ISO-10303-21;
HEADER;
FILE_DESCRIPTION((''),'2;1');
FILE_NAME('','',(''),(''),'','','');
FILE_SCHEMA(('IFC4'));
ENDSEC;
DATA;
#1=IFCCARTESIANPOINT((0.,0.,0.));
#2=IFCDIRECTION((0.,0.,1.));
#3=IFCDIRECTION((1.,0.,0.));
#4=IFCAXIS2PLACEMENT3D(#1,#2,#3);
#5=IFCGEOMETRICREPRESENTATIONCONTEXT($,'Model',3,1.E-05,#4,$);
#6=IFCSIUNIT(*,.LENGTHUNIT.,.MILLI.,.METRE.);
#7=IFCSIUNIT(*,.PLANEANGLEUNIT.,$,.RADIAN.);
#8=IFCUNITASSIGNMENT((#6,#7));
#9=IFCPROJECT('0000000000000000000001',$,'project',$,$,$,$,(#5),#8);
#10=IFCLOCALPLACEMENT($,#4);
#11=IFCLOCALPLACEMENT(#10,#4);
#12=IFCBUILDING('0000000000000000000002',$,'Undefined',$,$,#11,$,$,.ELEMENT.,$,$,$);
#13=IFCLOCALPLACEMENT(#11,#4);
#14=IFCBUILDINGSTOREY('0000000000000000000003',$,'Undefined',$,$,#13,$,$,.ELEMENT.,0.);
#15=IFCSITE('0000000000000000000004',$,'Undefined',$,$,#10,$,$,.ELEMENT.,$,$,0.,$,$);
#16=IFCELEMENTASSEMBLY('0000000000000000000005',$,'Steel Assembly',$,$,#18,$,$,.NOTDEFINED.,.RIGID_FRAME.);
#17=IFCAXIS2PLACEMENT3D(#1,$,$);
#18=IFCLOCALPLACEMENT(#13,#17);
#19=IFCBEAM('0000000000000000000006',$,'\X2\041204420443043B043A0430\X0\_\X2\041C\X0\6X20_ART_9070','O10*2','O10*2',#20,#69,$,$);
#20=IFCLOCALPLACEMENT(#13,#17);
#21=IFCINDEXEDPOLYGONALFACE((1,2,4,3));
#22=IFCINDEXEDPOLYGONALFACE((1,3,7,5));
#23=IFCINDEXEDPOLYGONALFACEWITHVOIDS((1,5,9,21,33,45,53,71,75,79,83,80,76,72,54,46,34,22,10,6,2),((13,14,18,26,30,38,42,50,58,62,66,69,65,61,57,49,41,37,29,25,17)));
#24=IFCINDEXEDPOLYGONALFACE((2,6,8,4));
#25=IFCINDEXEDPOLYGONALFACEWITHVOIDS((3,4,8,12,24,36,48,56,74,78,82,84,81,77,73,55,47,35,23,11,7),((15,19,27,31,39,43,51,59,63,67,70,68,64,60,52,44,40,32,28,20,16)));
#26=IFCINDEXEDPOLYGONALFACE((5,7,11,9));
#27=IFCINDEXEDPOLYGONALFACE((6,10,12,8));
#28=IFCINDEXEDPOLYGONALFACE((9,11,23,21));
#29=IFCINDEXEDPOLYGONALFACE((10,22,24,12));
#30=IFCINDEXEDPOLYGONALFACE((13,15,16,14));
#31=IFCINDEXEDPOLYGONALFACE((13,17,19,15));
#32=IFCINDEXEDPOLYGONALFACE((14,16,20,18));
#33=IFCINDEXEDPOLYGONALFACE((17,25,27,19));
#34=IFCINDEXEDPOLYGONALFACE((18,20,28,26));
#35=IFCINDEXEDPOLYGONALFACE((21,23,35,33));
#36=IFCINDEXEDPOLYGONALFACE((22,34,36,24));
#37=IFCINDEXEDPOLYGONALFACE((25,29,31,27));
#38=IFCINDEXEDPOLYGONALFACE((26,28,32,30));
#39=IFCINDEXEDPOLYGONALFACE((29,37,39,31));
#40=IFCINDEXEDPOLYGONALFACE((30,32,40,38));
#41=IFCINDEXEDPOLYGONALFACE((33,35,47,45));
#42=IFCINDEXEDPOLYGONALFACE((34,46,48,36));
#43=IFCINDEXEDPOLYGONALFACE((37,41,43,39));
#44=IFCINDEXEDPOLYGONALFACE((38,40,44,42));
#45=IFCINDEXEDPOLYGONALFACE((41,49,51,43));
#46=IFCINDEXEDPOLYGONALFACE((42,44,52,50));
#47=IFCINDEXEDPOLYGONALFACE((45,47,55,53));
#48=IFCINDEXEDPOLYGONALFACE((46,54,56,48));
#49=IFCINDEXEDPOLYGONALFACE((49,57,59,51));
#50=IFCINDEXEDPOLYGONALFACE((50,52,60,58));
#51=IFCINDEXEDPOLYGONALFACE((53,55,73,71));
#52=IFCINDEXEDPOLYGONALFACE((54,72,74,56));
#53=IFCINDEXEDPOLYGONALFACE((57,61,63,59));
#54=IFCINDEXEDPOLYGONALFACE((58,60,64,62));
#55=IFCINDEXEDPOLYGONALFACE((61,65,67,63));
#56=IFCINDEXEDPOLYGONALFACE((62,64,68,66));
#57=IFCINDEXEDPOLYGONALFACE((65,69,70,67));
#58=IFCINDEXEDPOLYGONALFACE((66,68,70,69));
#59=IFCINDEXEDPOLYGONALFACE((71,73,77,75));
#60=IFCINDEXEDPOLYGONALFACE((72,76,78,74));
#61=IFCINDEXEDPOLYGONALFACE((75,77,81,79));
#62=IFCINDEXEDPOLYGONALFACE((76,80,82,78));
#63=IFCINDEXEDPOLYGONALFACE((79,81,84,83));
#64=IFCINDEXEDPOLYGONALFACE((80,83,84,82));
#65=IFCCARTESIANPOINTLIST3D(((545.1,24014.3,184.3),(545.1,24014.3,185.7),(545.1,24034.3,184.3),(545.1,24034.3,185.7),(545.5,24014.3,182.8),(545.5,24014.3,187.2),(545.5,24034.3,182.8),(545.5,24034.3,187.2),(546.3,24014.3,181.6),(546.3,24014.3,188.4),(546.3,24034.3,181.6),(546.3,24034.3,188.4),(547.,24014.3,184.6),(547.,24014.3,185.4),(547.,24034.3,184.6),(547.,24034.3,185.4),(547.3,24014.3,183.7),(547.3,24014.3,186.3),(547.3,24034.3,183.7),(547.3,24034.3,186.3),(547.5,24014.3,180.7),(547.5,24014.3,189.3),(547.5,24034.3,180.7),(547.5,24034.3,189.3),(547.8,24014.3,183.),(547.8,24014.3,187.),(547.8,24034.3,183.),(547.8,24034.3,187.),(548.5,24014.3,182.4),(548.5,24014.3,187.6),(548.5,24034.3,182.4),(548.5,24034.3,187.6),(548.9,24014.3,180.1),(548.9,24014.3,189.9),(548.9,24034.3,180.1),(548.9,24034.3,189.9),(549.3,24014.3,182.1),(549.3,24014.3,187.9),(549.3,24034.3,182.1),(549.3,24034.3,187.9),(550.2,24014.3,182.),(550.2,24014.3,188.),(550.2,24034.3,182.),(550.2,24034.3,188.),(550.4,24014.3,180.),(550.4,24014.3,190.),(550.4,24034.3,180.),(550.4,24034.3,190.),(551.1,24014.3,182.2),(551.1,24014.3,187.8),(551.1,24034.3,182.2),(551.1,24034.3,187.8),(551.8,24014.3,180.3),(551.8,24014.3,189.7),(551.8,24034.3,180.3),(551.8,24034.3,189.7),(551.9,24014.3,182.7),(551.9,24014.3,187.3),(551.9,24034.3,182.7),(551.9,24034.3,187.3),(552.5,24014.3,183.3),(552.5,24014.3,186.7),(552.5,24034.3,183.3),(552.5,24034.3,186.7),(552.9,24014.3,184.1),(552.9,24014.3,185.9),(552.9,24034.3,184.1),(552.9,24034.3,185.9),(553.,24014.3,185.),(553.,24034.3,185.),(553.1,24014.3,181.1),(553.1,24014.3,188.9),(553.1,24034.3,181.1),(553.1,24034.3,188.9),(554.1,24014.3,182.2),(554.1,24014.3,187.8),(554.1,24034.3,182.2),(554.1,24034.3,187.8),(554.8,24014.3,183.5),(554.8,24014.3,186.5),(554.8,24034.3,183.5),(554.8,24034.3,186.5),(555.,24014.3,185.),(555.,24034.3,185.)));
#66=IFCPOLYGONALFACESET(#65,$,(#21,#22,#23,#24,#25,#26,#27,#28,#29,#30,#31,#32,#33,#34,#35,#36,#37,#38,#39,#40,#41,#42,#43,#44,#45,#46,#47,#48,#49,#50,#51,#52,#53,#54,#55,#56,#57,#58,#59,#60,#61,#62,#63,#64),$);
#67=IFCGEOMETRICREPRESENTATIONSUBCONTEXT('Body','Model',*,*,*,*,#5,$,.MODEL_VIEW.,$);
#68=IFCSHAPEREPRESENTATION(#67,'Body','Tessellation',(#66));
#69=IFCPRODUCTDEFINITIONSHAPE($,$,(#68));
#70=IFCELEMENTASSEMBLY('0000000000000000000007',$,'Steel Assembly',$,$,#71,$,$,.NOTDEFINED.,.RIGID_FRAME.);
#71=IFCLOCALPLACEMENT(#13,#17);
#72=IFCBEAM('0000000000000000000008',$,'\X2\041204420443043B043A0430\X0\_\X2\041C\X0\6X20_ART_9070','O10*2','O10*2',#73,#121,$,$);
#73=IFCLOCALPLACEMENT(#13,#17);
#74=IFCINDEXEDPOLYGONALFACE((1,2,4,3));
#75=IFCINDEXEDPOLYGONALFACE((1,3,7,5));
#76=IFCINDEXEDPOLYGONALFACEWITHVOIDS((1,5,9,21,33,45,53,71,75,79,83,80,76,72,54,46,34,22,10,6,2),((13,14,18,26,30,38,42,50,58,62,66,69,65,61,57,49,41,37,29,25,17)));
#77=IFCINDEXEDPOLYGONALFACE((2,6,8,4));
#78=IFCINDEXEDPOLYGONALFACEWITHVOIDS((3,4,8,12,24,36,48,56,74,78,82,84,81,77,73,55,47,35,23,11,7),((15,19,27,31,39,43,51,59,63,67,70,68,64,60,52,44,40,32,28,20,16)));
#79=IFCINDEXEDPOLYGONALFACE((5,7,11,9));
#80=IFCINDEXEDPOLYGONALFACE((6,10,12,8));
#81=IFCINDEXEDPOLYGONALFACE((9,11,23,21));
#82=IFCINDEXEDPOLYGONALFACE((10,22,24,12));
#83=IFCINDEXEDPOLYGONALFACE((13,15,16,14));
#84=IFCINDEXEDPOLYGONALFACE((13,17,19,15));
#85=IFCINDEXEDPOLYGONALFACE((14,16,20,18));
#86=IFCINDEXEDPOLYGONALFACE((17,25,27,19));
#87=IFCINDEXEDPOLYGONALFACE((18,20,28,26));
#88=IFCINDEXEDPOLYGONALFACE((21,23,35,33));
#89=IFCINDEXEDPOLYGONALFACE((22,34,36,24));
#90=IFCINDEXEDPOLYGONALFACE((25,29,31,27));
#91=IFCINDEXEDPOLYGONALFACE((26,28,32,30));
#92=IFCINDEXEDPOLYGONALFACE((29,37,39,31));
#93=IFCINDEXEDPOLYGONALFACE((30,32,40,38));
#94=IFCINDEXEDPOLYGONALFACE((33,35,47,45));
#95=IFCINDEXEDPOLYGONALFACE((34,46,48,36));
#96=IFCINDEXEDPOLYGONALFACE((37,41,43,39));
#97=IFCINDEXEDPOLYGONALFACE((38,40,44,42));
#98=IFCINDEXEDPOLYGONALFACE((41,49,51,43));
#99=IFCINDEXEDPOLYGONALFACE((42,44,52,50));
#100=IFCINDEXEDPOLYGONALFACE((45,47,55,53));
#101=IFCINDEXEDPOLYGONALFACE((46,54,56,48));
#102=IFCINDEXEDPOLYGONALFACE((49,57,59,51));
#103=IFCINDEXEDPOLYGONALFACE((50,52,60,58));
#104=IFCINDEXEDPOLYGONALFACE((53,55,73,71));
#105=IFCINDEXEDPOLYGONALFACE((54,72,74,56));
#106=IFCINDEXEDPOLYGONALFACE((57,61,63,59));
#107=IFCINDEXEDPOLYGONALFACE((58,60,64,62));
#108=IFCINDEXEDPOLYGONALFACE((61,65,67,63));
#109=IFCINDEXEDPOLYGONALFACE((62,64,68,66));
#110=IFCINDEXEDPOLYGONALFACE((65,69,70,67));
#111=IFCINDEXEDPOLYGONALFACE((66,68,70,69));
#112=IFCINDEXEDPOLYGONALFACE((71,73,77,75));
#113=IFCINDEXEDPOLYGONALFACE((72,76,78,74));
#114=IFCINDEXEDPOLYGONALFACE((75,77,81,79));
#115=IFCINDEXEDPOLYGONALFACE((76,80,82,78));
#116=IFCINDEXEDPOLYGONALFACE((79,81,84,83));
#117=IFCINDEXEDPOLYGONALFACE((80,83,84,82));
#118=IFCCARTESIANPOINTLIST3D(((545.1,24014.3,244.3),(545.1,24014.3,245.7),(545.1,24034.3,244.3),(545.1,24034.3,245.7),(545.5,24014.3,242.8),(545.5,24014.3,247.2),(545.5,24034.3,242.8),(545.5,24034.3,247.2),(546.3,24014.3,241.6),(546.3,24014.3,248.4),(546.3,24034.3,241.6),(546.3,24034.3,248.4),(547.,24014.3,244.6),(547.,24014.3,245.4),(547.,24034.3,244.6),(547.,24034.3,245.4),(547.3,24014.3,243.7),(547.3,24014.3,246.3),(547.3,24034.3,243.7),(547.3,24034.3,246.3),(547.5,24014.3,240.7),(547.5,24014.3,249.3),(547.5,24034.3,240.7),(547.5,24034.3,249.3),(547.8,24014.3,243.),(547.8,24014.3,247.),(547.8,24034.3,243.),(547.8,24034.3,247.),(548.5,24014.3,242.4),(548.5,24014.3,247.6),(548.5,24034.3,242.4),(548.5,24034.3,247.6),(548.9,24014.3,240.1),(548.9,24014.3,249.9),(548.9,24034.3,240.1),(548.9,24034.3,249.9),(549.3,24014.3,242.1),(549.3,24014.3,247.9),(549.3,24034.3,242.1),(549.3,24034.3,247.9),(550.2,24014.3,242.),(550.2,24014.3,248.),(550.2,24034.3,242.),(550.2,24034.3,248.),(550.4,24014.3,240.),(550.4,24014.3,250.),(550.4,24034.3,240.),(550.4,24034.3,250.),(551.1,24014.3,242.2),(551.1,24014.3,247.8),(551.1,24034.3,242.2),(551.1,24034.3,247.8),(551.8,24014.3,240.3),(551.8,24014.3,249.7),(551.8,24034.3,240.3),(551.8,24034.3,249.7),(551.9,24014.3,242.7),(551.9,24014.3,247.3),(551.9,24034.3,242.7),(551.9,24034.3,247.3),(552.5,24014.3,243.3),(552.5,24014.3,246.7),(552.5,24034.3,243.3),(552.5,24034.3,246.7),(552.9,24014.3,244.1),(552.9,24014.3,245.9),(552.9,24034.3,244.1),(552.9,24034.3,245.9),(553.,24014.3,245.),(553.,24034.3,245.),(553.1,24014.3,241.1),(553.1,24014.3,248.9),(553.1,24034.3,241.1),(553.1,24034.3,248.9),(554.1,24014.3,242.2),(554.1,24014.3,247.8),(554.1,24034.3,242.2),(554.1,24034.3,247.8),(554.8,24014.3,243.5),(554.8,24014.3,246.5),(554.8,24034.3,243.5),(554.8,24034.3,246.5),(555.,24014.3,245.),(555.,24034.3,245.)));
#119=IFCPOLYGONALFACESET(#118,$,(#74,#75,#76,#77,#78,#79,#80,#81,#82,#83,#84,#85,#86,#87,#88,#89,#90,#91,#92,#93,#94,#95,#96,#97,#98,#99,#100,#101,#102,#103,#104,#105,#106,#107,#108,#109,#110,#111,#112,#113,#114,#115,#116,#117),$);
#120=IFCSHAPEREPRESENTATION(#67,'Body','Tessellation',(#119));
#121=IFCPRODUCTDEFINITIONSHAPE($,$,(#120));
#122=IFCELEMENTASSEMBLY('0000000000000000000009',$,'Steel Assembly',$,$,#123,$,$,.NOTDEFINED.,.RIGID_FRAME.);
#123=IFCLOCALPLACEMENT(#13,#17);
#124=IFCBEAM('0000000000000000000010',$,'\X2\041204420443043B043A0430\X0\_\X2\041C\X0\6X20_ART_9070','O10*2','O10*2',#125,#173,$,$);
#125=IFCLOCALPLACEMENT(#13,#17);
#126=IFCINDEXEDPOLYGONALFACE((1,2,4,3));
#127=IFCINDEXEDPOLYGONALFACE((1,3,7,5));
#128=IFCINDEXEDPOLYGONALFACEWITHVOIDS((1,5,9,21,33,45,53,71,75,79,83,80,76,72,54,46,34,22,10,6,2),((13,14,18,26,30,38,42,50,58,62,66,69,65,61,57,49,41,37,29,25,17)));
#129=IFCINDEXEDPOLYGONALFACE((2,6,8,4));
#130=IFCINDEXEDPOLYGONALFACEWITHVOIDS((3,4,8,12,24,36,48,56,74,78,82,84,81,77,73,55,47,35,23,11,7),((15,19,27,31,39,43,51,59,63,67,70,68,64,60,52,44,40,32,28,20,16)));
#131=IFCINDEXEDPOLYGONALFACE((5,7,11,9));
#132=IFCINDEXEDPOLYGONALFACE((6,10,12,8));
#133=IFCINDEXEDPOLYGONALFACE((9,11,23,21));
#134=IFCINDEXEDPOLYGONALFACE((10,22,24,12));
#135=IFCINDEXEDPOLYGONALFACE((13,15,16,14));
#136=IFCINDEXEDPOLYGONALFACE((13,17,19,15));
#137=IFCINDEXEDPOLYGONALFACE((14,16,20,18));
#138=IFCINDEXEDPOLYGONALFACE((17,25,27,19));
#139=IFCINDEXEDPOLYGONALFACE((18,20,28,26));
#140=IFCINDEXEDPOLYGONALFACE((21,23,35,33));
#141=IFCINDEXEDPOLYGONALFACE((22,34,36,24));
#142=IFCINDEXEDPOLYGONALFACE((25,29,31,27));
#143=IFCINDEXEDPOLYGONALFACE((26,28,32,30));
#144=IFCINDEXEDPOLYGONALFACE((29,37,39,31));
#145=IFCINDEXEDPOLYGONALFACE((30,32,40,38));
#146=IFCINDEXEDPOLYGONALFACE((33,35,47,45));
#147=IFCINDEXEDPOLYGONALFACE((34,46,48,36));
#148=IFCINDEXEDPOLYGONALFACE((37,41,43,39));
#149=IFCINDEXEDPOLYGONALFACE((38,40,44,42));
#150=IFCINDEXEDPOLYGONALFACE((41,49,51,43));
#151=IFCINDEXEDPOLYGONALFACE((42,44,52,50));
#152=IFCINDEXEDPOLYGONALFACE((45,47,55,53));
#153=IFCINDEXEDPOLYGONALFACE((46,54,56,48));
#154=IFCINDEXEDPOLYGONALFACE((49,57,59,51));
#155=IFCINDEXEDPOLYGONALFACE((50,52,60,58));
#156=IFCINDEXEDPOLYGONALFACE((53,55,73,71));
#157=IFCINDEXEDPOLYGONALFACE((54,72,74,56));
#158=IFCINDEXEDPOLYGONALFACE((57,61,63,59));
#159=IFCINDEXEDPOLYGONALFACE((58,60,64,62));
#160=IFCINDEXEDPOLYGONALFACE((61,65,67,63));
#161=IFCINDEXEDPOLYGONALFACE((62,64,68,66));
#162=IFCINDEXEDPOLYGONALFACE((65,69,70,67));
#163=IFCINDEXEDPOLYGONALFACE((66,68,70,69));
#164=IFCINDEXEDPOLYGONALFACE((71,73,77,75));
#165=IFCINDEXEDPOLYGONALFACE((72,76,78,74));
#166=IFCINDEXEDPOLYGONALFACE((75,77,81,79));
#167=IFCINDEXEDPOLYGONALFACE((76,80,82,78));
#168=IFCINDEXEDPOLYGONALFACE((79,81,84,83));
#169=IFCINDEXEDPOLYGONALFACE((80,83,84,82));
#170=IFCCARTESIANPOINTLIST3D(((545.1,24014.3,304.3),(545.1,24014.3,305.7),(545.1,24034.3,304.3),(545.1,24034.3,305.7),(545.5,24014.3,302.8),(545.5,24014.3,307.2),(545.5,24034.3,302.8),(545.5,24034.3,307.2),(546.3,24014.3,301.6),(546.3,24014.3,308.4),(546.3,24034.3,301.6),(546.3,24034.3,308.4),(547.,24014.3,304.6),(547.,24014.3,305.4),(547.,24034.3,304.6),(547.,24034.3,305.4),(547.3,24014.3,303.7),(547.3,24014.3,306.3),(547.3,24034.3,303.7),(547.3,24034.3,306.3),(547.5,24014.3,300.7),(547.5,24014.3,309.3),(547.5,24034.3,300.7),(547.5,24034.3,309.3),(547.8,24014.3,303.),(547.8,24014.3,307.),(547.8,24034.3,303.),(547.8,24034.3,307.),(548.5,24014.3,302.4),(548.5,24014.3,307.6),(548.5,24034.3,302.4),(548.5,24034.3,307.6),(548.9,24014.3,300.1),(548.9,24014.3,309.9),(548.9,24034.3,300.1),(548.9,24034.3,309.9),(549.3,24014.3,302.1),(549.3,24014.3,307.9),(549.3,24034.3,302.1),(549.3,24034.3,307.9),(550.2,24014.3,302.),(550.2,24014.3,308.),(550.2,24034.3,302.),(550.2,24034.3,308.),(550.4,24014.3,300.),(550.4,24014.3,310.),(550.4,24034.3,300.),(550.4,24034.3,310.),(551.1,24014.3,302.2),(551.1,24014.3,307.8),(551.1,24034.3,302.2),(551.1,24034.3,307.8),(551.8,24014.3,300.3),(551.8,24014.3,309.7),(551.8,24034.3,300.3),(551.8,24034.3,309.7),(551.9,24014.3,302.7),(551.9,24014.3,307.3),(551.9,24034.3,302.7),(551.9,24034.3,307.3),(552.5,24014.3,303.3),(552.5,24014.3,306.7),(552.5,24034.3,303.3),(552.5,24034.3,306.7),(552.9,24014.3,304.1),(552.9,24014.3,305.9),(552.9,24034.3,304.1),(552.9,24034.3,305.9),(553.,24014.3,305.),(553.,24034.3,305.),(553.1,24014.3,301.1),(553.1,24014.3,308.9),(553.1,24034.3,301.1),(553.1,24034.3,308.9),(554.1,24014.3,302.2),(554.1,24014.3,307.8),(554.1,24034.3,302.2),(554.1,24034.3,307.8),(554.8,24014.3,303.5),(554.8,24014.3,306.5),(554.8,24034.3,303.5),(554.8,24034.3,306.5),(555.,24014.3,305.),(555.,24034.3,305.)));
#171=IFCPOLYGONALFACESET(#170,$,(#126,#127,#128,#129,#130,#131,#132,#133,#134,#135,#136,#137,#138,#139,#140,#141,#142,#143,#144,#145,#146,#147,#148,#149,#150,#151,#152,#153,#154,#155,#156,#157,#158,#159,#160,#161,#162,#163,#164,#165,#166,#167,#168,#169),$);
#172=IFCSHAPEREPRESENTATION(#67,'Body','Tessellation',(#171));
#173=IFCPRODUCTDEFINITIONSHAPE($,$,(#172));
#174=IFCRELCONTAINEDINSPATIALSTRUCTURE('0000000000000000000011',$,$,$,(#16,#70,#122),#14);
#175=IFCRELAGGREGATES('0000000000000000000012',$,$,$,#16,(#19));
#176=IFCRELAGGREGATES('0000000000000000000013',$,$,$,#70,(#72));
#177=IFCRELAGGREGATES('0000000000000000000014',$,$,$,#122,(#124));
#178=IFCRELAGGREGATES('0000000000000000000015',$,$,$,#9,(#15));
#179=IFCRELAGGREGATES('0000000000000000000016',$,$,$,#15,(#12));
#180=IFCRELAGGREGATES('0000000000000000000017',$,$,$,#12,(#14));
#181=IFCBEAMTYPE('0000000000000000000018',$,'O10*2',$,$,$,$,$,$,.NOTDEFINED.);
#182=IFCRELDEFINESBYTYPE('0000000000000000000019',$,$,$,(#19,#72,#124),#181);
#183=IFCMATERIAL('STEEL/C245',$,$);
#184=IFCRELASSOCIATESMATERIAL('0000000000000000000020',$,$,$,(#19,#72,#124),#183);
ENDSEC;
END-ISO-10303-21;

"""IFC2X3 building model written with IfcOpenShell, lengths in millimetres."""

from ifc_helpers import new_model, si_unit, frame, origin_with_axes, origin_2d_with_axis, place, context, subcontext, project, spatial, hollow_circle, extrude, material, type_object, element, aggregate, save


model = new_model("IFC2X3")

# Units and contexts
model_context = context("Model", 3, precision=1e-05, world=origin_with_axes())
body_context = subcontext(model_context, "Body", "Model", "MODEL_VIEW")
ifc_project = project(units=[si_unit("LENGTHUNIT", "METRE", prefix="MILLI"), si_unit("PLANEANGLEUNIT", "RADIAN")], contexts=[model_context])

# Site, building, storey
site_placement = place(None, origin_with_axes())
site = spatial("IfcSite", under=ifc_project, at=site_placement, Name="Undefined", CompositionType="ELEMENT", RefElevation=0.0)
building_placement = place(site_placement, origin_with_axes())
building = spatial("IfcBuilding", under=site, at=building_placement, Name="Undefined", CompositionType="ELEMENT")
storey_placement = place(building_placement, origin_with_axes())
storey = spatial("IfcBuildingStorey", under=building, at=storey_placement, Name="Undefined", CompositionType="ELEMENT", Elevation=0.0)

# Element assemblies, beams
ifc_material_1 = material(Name="STEEL/C245")
beam_type_1 = type_object("IfcBeamType", Name="O10*2", PredefinedType="NOTDEFINED")
assembly_1_placement = place(storey_placement, origin_with_axes())
assembly_1 = element("IfcElementAssembly", 1, at=assembly_1_placement, inside=storey, Name="Steel Assembly", AssemblyPlace="NOTDEFINED", PredefinedType="RIGID_FRAME")
beam_1_placement = place(assembly_1_placement, frame((550.0, 24014.3, 185.0), z_axis=(0.0, 0.0, 1.0), x_axis=(0.0, 1.0, 0.0)))
beam_1 = element("IfcBeam", 2, at=beam_1_placement, type_object=beam_type_1, material=ifc_material_1, Name="Втулка_М6X20_ART_9070", Description="O10*2", ObjectType="O10*2", context=body_context, shape_type="SweptSolid", body=[
    extrude(hollow_circle(Radius=5.0, WallThickness=2.0, at=origin_2d_with_axis()), frame((20.0, 0.0, 0.0), z_axis=(-1.0, 0.0, 0.0), x_axis=(0.0, -1.0, 0.0)), (0.0, 0.0, 1.0), 20.0),
])
aggregate(assembly_1, [beam_1])
assembly_2_placement = place(storey_placement, origin_with_axes())
assembly_2 = element("IfcElementAssembly", 3, at=assembly_2_placement, inside=storey, Name="Steel Assembly", AssemblyPlace="NOTDEFINED", PredefinedType="RIGID_FRAME")
beam_2_placement = place(assembly_2_placement, frame((550.0, 24014.3, 245.0), z_axis=(0.0, 0.0, 1.0), x_axis=(0.0, 1.0, 0.0)))
beam_2 = element("IfcBeam", 4, at=beam_2_placement, type_object=beam_type_1, material=ifc_material_1, Name="Втулка_М6X20_ART_9070", Description="O10*2", ObjectType="O10*2", context=body_context, shape_type="SweptSolid", body=[
    extrude(hollow_circle(Radius=5.0, WallThickness=2.0, at=origin_2d_with_axis()), frame((20.0, 0.0, 0.0), z_axis=(-1.0, 0.0, 0.0), x_axis=(0.0, -1.0, 0.0)), (0.0, 0.0, 1.0), 20.0),
])
aggregate(assembly_2, [beam_2])
assembly_3_placement = place(storey_placement, origin_with_axes())
assembly_3 = element("IfcElementAssembly", 5, at=assembly_3_placement, inside=storey, Name="Steel Assembly", AssemblyPlace="NOTDEFINED", PredefinedType="RIGID_FRAME")
beam_3_placement = place(assembly_3_placement, frame((550.0, 24014.3, 305.0), z_axis=(0.0, 0.0, 1.0), x_axis=(0.0, 1.0, 0.0)))
beam_3 = element("IfcBeam", 6, at=beam_3_placement, type_object=beam_type_1, material=ifc_material_1, Name="Втулка_М6X20_ART_9070", Description="O10*2", ObjectType="O10*2", context=body_context, shape_type="SweptSolid", body=[
    extrude(hollow_circle(Radius=5.0, WallThickness=2.0, at=origin_2d_with_axis()), frame((20.0, 0.0, 0.0), z_axis=(-1.0, 0.0, 0.0), x_axis=(0.0, -1.0, 0.0)), (0.0, 0.0, 1.0), 20.0),
])
aggregate(assembly_3, [beam_3])

save(model, "model.ifc")
